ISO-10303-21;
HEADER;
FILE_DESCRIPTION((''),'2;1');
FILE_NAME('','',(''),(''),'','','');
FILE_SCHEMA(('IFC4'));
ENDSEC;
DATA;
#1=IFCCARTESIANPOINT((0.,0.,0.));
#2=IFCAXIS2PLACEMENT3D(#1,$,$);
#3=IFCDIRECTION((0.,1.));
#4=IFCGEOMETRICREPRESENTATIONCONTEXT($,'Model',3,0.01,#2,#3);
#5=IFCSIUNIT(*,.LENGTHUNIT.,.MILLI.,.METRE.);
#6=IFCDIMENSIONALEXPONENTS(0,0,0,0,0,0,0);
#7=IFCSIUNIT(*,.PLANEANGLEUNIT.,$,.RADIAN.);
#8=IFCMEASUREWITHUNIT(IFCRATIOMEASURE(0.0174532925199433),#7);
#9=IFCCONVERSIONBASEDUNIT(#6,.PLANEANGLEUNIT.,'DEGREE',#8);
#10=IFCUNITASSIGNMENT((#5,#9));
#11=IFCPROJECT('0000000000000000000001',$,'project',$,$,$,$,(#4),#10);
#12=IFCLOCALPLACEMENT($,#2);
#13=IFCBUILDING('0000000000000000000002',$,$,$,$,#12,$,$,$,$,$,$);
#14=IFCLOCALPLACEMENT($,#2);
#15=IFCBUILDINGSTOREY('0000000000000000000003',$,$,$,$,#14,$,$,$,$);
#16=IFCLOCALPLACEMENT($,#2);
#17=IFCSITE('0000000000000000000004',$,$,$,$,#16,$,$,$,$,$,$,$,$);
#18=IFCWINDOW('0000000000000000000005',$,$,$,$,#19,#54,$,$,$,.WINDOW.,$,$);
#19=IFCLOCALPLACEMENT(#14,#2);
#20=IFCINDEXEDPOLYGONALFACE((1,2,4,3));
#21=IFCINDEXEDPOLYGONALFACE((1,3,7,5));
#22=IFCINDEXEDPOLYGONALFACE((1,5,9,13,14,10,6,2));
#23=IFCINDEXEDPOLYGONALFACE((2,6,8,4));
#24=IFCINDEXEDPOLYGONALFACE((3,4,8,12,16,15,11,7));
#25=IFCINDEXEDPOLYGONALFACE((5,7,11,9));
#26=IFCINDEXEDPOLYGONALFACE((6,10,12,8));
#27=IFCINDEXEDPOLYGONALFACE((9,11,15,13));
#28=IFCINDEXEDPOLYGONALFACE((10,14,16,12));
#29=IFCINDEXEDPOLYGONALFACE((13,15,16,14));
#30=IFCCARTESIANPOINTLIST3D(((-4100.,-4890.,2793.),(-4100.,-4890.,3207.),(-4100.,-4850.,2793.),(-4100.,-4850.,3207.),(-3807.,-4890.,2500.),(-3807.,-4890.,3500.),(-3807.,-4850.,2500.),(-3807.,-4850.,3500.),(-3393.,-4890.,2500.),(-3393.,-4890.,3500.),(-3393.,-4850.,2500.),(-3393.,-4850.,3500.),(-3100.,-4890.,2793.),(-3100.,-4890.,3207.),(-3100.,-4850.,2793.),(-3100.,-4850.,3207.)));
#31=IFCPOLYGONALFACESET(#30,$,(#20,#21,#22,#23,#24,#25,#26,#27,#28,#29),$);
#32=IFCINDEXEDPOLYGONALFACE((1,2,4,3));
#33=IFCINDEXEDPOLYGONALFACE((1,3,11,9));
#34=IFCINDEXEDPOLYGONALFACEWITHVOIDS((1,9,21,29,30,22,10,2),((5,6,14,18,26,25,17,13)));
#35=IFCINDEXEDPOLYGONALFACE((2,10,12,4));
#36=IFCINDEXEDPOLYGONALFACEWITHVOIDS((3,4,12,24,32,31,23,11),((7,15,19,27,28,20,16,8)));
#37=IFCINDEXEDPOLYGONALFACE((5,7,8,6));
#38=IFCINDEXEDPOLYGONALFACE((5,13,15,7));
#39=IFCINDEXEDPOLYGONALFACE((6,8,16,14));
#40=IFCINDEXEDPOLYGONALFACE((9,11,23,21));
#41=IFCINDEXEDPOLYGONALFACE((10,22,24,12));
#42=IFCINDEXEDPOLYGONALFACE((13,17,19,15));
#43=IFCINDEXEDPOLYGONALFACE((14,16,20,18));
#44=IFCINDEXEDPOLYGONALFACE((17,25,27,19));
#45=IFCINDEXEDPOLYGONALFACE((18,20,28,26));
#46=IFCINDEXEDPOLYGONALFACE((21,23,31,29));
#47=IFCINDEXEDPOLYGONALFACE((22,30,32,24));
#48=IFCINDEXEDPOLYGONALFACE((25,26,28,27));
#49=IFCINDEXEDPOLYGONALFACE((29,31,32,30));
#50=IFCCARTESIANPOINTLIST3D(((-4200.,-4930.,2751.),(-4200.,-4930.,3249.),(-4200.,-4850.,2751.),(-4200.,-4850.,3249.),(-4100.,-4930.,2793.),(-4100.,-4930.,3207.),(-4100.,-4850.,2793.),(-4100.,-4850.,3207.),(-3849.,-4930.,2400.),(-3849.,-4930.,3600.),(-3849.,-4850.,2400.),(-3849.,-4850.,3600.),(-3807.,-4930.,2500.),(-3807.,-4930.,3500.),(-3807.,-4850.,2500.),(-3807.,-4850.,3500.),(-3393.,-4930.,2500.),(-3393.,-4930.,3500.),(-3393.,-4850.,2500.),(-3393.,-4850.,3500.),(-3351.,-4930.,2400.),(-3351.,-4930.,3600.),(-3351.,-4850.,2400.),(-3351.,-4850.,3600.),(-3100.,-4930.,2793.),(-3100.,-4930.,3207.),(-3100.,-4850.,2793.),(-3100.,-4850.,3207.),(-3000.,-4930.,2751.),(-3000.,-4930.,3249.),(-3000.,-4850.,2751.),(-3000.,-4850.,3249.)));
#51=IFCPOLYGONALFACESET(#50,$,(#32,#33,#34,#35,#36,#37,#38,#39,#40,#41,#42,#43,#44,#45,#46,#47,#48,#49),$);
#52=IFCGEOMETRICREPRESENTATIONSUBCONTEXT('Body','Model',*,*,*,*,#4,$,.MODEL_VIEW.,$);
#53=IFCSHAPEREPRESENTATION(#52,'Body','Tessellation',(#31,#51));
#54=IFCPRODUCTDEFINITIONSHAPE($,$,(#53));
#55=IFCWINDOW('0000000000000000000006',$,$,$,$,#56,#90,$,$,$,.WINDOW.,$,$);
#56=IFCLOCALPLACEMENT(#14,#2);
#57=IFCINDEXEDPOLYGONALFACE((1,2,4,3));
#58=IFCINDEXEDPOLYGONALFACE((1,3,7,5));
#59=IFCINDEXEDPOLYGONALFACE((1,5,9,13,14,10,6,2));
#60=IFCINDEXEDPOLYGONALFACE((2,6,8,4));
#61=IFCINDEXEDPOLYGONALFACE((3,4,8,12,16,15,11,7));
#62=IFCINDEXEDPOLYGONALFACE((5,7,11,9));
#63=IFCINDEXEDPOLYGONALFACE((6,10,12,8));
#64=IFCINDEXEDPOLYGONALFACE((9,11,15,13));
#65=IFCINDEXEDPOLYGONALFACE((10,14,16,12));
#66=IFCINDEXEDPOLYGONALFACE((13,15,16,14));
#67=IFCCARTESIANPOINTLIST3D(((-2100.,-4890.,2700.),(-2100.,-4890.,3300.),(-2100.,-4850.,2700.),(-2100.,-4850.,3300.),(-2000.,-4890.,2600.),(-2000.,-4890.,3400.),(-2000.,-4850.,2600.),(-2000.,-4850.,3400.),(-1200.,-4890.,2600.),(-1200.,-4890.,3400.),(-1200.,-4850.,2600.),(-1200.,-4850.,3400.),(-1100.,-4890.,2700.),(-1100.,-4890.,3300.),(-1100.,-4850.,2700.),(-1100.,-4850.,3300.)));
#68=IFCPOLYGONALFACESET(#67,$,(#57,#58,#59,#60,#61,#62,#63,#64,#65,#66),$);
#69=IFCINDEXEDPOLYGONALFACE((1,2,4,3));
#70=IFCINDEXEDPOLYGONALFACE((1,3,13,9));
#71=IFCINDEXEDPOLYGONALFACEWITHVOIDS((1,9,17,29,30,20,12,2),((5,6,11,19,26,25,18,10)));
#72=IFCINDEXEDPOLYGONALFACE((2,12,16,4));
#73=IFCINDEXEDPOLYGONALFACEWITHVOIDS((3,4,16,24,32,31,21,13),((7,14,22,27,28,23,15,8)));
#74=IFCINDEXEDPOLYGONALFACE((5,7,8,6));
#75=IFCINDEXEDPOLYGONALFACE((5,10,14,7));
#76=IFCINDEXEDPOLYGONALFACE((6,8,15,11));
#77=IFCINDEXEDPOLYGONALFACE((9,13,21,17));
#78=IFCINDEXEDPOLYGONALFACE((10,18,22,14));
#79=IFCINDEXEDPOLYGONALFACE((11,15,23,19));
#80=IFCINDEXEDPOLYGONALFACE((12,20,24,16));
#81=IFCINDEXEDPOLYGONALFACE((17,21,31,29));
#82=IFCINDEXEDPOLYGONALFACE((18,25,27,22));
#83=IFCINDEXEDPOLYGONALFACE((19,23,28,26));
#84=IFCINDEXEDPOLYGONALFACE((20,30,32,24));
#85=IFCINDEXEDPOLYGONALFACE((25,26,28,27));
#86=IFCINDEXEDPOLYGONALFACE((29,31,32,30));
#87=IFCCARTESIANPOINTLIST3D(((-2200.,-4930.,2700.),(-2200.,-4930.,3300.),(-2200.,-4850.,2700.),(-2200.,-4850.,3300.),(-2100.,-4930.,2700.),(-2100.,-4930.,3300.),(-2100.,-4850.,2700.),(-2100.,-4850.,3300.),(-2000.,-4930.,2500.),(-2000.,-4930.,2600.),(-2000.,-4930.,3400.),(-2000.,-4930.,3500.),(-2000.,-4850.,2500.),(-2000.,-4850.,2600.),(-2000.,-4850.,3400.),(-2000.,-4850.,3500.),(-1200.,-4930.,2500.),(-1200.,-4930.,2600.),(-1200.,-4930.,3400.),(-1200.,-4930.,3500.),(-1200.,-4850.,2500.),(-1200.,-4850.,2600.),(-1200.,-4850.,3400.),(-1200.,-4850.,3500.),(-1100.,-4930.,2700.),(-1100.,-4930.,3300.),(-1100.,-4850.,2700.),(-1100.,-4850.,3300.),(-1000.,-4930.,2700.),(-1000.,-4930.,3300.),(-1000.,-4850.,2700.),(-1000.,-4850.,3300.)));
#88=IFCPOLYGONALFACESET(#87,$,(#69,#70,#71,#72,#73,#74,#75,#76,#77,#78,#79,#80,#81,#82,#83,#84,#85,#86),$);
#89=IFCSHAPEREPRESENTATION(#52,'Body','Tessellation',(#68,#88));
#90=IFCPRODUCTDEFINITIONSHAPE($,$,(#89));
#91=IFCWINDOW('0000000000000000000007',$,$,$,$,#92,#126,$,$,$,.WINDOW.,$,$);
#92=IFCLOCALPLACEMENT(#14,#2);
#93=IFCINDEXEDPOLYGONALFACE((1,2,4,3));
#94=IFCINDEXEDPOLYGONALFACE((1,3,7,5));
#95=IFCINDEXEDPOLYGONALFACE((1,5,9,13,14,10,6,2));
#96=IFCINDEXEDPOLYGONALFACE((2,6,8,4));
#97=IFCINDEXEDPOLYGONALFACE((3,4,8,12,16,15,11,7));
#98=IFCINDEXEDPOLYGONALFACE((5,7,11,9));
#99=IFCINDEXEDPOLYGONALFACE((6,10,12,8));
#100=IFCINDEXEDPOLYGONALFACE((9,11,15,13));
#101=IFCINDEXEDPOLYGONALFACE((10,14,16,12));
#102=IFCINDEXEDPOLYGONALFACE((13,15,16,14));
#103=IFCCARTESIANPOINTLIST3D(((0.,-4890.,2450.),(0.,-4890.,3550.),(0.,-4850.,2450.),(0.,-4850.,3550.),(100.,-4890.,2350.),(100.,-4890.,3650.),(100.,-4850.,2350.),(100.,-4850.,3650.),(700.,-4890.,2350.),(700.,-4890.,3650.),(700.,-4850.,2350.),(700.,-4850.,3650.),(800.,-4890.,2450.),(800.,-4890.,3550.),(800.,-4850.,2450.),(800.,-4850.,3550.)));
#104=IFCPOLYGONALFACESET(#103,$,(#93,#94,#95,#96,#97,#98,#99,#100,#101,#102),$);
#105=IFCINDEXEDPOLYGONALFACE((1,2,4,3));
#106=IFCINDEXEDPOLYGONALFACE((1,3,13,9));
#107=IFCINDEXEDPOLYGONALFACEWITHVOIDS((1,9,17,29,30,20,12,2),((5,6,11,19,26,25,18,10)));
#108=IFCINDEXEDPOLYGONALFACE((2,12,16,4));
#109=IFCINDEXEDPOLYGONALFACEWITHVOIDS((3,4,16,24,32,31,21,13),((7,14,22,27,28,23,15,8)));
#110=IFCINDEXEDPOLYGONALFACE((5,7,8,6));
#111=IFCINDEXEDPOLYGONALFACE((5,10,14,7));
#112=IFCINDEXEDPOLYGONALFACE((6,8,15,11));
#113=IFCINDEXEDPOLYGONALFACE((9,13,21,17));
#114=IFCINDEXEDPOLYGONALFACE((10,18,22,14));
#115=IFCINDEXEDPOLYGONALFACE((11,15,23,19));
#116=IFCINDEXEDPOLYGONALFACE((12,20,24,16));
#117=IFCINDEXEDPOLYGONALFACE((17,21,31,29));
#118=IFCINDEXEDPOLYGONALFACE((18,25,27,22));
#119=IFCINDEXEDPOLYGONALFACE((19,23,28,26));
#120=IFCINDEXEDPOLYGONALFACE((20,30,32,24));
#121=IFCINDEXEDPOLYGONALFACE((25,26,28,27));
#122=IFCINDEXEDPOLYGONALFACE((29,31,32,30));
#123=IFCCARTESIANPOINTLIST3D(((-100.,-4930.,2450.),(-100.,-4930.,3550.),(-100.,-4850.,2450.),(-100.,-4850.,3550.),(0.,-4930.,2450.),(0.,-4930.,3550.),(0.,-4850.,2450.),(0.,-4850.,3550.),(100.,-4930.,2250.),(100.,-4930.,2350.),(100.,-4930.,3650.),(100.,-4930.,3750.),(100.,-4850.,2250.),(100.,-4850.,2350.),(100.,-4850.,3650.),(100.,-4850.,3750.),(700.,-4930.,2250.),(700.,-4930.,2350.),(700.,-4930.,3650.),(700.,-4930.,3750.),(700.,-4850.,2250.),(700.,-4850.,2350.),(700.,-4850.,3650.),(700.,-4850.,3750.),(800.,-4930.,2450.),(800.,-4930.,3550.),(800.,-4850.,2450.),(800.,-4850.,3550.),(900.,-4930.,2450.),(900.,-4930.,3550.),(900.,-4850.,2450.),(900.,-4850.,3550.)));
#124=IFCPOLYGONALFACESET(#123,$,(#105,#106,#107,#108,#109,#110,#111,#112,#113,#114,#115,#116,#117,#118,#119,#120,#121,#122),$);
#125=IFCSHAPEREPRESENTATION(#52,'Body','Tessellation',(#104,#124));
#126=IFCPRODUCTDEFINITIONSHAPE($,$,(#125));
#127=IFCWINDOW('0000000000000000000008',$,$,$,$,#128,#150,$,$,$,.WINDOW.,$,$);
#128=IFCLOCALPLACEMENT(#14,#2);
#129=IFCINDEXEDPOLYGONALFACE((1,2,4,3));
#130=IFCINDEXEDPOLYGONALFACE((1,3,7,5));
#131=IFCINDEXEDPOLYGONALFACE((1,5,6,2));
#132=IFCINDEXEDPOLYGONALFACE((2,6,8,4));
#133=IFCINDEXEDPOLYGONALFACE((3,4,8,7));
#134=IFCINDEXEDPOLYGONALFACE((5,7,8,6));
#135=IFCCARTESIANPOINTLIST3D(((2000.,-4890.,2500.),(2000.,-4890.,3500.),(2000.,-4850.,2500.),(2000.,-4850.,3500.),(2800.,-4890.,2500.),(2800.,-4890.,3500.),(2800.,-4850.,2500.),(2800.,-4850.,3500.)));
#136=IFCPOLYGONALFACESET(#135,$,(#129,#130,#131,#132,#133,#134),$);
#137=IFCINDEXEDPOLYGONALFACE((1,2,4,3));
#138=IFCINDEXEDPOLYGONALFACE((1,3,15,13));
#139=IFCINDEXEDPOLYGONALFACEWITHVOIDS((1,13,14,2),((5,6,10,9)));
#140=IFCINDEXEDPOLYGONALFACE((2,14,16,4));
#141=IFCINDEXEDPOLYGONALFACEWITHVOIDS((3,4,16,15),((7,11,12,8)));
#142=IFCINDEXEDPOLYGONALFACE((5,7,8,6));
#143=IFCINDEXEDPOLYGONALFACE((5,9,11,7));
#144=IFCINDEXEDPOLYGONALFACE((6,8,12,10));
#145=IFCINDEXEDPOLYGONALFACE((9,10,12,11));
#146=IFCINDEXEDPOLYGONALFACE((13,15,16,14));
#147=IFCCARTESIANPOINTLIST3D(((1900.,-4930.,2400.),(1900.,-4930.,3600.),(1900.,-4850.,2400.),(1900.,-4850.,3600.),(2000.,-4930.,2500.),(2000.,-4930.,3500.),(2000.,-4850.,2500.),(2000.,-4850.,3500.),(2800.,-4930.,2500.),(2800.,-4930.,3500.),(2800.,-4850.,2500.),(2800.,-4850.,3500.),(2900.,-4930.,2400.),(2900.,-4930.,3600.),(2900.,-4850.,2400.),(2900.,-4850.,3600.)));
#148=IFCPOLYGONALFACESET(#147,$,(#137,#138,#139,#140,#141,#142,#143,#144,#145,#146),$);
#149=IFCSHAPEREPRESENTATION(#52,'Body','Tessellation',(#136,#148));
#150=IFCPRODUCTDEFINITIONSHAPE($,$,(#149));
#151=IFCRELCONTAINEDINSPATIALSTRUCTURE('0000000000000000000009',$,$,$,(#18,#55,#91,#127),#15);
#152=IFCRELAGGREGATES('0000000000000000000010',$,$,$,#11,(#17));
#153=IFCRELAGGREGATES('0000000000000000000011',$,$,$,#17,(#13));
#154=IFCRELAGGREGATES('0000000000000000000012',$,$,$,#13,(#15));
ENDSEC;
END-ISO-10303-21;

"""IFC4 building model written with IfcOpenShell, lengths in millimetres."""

from ifc_helpers import new_model, entity, si_unit, converted_unit, direction, frame, origin, place, context, subcontext, project, spatial, element, save


model = new_model("IFC4")

# Units and contexts
model_context = context("Model", 3, precision=0.01, world=origin(), true_north=direction((0.0, 1.0)))
body_context = subcontext(model_context, "Body", "Model", "MODEL_VIEW")
ifc_project = project(units=[si_unit("LENGTHUNIT", "METRE", prefix="MILLI"), converted_unit("PLANEANGLEUNIT", "DEGREE", entity("IfcRatioMeasure", 0.0174532925199433), si_unit("PLANEANGLEUNIT", "RADIAN"), dimensions=[0, 0, 0, 0, 0, 0, 0])], contexts=[model_context])

# Site, building, storey
site_placement = place(None, origin())
site = spatial("IfcSite", under=ifc_project, at=site_placement)
building_placement = place(None, origin())
building = spatial("IfcBuilding", under=site, at=building_placement)
storey_placement = place(None, origin())
storey = spatial("IfcBuildingStorey", under=building, at=storey_placement)

# Shared definitions
cartesian_point_1 = entity("IfcCartesianPoint", [-500.0, -207.0])
shared_polyline_1 = entity("IfcPolyline", [cartesian_point_1, entity("IfcCartesianPoint", [-500.0, 207.0]), entity("IfcCartesianPoint", [-207.0, 500.0]), entity("IfcCartesianPoint", [207.0, 500.0]), entity("IfcCartesianPoint", [500.0, 207.0]), entity("IfcCartesianPoint", [500.0, -207.0]), entity("IfcCartesianPoint", [207.0, -500.0]), entity("IfcCartesianPoint", [-207.0, -500.0]), cartesian_point_1])
cartesian_point_2 = entity("IfcCartesianPoint", [-500.0, -300.0])
shared_polyline_2 = entity("IfcPolyline", [cartesian_point_2, entity("IfcCartesianPoint", [-500.0, 300.0]), entity("IfcCartesianPoint", [-400.0, 400.0]), entity("IfcCartesianPoint", [400.0, 400.0]), entity("IfcCartesianPoint", [500.0, 300.0]), entity("IfcCartesianPoint", [500.0, -300.0]), entity("IfcCartesianPoint", [400.0, -400.0]), entity("IfcCartesianPoint", [-400.0, -400.0]), cartesian_point_2])
cartesian_point_3 = entity("IfcCartesianPoint", [-400.0, -550.0])
shared_polyline_3 = entity("IfcPolyline", [cartesian_point_3, entity("IfcCartesianPoint", [-400.0, 550.0]), entity("IfcCartesianPoint", [-300.0, 650.0]), entity("IfcCartesianPoint", [300.0, 650.0]), entity("IfcCartesianPoint", [400.0, 550.0]), entity("IfcCartesianPoint", [400.0, -550.0]), entity("IfcCartesianPoint", [300.0, -650.0]), entity("IfcCartesianPoint", [-300.0, -650.0]), cartesian_point_3])
cartesian_point_4 = entity("IfcCartesianPoint", [-400.0, -500.0])
shared_polyline_4 = entity("IfcPolyline", [cartesian_point_4, entity("IfcCartesianPoint", [-400.0, 500.0]), entity("IfcCartesianPoint", [-400.0, 500.0]), entity("IfcCartesianPoint", [400.0, 500.0]), entity("IfcCartesianPoint", [400.0, 500.0]), entity("IfcCartesianPoint", [400.0, -500.0]), entity("IfcCartesianPoint", [400.0, -500.0]), entity("IfcCartesianPoint", [-400.0, -500.0]), cartesian_point_4])

# Shared definitions
wall_1_placement = place(storey_placement, frame((-100.0, -4900.0, 0.0), z_axis=(0.0, 0.0, 1.0), x_axis=(1.0, 0.0, 0.0)))
window_1_placement = place(wall_1_placement, frame((-3500.0, 50.0, 3000.0)))
window_2_placement = place(wall_1_placement, frame((-1500.0, 50.0, 3000.0)))
window_3_placement = place(wall_1_placement, frame((500.0, 50.0, 3000.0)))
window_4_placement = place(wall_1_placement, frame((2500.0, 50.0, 3000.0)))

# Windows
cartesian_point_5 = entity("IfcCartesianPoint", [-600.0, -249.0])
element("IfcWindow", 1, at=window_1_placement, inside=storey, PredefinedType="WINDOW", context=body_context, shape_type="SweptSolid", body=[
    entity("IfcExtrudedAreaSolid", entity("IfcArbitraryClosedProfileDef", "AREA", None, shared_polyline_1), entity("IfcAxis2Placement3D", entity("IfcCartesianPoint", [0.0, 0.0, 0.0]), entity("IfcDirection", [0.0, -1.0, 0.0]), entity("IfcDirection", [1.0, 0.0, 0.0])), entity("IfcDirection", [0.0, 0.0, 1.0]), 40.0),
    entity("IfcExtrudedAreaSolid", entity("IfcArbitraryProfileDefWithVoids", "AREA", None, entity("IfcPolyline", [cartesian_point_5, entity("IfcCartesianPoint", [-600.0, 249.0]), entity("IfcCartesianPoint", [-249.0, 600.0]), entity("IfcCartesianPoint", [249.0, 600.0]), entity("IfcCartesianPoint", [600.0, 249.0]), entity("IfcCartesianPoint", [600.0, -249.0]), entity("IfcCartesianPoint", [249.0, -600.0]), entity("IfcCartesianPoint", [-249.0, -600.0]), cartesian_point_5]), [shared_polyline_1]), entity("IfcAxis2Placement3D", entity("IfcCartesianPoint", [0.0, 0.0, 0.0]), entity("IfcDirection", [0.0, -1.0, 0.0]), entity("IfcDirection", [1.0, 0.0, 0.0])), entity("IfcDirection", [0.0, 0.0, 1.0]), 80.0),
])
cartesian_point_6 = entity("IfcCartesianPoint", [-600.0, -300.0])
element("IfcWindow", 2, at=window_2_placement, inside=storey, PredefinedType="WINDOW", context=body_context, shape_type="SweptSolid", body=[
    entity("IfcExtrudedAreaSolid", entity("IfcArbitraryClosedProfileDef", "AREA", None, shared_polyline_2), entity("IfcAxis2Placement3D", entity("IfcCartesianPoint", [0.0, 0.0, 0.0]), entity("IfcDirection", [0.0, -1.0, 0.0]), entity("IfcDirection", [1.0, 0.0, 0.0])), entity("IfcDirection", [0.0, 0.0, 1.0]), 40.0),
    entity("IfcExtrudedAreaSolid", entity("IfcArbitraryProfileDefWithVoids", "AREA", None, entity("IfcPolyline", [cartesian_point_6, entity("IfcCartesianPoint", [-600.0, 300.0]), entity("IfcCartesianPoint", [-400.0, 500.0]), entity("IfcCartesianPoint", [400.0, 500.0]), entity("IfcCartesianPoint", [600.0, 300.0]), entity("IfcCartesianPoint", [600.0, -300.0]), entity("IfcCartesianPoint", [400.0, -500.0]), entity("IfcCartesianPoint", [-400.0, -500.0]), cartesian_point_6]), [shared_polyline_2]), entity("IfcAxis2Placement3D", entity("IfcCartesianPoint", [0.0, 0.0, 0.0]), entity("IfcDirection", [0.0, -1.0, 0.0]), entity("IfcDirection", [1.0, 0.0, 0.0])), entity("IfcDirection", [0.0, 0.0, 1.0]), 80.0),
])
cartesian_point_7 = entity("IfcCartesianPoint", [-500.0, -550.0])
element("IfcWindow", 3, at=window_3_placement, inside=storey, PredefinedType="WINDOW", context=body_context, shape_type="SweptSolid", body=[
    entity("IfcExtrudedAreaSolid", entity("IfcArbitraryClosedProfileDef", "AREA", None, shared_polyline_3), entity("IfcAxis2Placement3D", entity("IfcCartesianPoint", [0.0, 0.0, 0.0]), entity("IfcDirection", [0.0, -1.0, 0.0]), entity("IfcDirection", [1.0, 0.0, 0.0])), entity("IfcDirection", [0.0, 0.0, 1.0]), 40.0),
    entity("IfcExtrudedAreaSolid", entity("IfcArbitraryProfileDefWithVoids", "AREA", None, entity("IfcPolyline", [cartesian_point_7, entity("IfcCartesianPoint", [-500.0, 550.0]), entity("IfcCartesianPoint", [-300.0, 750.0]), entity("IfcCartesianPoint", [300.0, 750.0]), entity("IfcCartesianPoint", [500.0, 550.0]), entity("IfcCartesianPoint", [500.0, -550.0]), entity("IfcCartesianPoint", [300.0, -750.0]), entity("IfcCartesianPoint", [-300.0, -750.0]), cartesian_point_7]), [shared_polyline_3]), entity("IfcAxis2Placement3D", entity("IfcCartesianPoint", [0.0, 0.0, 0.0]), entity("IfcDirection", [0.0, -1.0, 0.0]), entity("IfcDirection", [1.0, 0.0, 0.0])), entity("IfcDirection", [0.0, 0.0, 1.0]), 80.0),
])
cartesian_point_8 = entity("IfcCartesianPoint", [-500.0, -600.0])
element("IfcWindow", 4, at=window_4_placement, inside=storey, PredefinedType="WINDOW", context=body_context, shape_type="SweptSolid", body=[
    entity("IfcExtrudedAreaSolid", entity("IfcArbitraryClosedProfileDef", "AREA", None, shared_polyline_4), entity("IfcAxis2Placement3D", entity("IfcCartesianPoint", [0.0, 0.0, 0.0]), entity("IfcDirection", [0.0, -1.0, 0.0]), entity("IfcDirection", [1.0, 0.0, 0.0])), entity("IfcDirection", [0.0, 0.0, 1.0]), 40.0),
    entity("IfcExtrudedAreaSolid", entity("IfcArbitraryProfileDefWithVoids", "AREA", None, entity("IfcPolyline", [cartesian_point_8, entity("IfcCartesianPoint", [-500.0, 600.0]), entity("IfcCartesianPoint", [-500.0, 600.0]), entity("IfcCartesianPoint", [500.0, 600.0]), entity("IfcCartesianPoint", [500.0, 600.0]), entity("IfcCartesianPoint", [500.0, -600.0]), entity("IfcCartesianPoint", [500.0, -600.0]), entity("IfcCartesianPoint", [-500.0, -600.0]), cartesian_point_8]), [shared_polyline_4]), entity("IfcAxis2Placement3D", entity("IfcCartesianPoint", [0.0, 0.0, 0.0]), entity("IfcDirection", [0.0, -1.0, 0.0]), entity("IfcDirection", [1.0, 0.0, 0.0])), entity("IfcDirection", [0.0, 0.0, 1.0]), 80.0),
])

save(model, "model.ifc")
